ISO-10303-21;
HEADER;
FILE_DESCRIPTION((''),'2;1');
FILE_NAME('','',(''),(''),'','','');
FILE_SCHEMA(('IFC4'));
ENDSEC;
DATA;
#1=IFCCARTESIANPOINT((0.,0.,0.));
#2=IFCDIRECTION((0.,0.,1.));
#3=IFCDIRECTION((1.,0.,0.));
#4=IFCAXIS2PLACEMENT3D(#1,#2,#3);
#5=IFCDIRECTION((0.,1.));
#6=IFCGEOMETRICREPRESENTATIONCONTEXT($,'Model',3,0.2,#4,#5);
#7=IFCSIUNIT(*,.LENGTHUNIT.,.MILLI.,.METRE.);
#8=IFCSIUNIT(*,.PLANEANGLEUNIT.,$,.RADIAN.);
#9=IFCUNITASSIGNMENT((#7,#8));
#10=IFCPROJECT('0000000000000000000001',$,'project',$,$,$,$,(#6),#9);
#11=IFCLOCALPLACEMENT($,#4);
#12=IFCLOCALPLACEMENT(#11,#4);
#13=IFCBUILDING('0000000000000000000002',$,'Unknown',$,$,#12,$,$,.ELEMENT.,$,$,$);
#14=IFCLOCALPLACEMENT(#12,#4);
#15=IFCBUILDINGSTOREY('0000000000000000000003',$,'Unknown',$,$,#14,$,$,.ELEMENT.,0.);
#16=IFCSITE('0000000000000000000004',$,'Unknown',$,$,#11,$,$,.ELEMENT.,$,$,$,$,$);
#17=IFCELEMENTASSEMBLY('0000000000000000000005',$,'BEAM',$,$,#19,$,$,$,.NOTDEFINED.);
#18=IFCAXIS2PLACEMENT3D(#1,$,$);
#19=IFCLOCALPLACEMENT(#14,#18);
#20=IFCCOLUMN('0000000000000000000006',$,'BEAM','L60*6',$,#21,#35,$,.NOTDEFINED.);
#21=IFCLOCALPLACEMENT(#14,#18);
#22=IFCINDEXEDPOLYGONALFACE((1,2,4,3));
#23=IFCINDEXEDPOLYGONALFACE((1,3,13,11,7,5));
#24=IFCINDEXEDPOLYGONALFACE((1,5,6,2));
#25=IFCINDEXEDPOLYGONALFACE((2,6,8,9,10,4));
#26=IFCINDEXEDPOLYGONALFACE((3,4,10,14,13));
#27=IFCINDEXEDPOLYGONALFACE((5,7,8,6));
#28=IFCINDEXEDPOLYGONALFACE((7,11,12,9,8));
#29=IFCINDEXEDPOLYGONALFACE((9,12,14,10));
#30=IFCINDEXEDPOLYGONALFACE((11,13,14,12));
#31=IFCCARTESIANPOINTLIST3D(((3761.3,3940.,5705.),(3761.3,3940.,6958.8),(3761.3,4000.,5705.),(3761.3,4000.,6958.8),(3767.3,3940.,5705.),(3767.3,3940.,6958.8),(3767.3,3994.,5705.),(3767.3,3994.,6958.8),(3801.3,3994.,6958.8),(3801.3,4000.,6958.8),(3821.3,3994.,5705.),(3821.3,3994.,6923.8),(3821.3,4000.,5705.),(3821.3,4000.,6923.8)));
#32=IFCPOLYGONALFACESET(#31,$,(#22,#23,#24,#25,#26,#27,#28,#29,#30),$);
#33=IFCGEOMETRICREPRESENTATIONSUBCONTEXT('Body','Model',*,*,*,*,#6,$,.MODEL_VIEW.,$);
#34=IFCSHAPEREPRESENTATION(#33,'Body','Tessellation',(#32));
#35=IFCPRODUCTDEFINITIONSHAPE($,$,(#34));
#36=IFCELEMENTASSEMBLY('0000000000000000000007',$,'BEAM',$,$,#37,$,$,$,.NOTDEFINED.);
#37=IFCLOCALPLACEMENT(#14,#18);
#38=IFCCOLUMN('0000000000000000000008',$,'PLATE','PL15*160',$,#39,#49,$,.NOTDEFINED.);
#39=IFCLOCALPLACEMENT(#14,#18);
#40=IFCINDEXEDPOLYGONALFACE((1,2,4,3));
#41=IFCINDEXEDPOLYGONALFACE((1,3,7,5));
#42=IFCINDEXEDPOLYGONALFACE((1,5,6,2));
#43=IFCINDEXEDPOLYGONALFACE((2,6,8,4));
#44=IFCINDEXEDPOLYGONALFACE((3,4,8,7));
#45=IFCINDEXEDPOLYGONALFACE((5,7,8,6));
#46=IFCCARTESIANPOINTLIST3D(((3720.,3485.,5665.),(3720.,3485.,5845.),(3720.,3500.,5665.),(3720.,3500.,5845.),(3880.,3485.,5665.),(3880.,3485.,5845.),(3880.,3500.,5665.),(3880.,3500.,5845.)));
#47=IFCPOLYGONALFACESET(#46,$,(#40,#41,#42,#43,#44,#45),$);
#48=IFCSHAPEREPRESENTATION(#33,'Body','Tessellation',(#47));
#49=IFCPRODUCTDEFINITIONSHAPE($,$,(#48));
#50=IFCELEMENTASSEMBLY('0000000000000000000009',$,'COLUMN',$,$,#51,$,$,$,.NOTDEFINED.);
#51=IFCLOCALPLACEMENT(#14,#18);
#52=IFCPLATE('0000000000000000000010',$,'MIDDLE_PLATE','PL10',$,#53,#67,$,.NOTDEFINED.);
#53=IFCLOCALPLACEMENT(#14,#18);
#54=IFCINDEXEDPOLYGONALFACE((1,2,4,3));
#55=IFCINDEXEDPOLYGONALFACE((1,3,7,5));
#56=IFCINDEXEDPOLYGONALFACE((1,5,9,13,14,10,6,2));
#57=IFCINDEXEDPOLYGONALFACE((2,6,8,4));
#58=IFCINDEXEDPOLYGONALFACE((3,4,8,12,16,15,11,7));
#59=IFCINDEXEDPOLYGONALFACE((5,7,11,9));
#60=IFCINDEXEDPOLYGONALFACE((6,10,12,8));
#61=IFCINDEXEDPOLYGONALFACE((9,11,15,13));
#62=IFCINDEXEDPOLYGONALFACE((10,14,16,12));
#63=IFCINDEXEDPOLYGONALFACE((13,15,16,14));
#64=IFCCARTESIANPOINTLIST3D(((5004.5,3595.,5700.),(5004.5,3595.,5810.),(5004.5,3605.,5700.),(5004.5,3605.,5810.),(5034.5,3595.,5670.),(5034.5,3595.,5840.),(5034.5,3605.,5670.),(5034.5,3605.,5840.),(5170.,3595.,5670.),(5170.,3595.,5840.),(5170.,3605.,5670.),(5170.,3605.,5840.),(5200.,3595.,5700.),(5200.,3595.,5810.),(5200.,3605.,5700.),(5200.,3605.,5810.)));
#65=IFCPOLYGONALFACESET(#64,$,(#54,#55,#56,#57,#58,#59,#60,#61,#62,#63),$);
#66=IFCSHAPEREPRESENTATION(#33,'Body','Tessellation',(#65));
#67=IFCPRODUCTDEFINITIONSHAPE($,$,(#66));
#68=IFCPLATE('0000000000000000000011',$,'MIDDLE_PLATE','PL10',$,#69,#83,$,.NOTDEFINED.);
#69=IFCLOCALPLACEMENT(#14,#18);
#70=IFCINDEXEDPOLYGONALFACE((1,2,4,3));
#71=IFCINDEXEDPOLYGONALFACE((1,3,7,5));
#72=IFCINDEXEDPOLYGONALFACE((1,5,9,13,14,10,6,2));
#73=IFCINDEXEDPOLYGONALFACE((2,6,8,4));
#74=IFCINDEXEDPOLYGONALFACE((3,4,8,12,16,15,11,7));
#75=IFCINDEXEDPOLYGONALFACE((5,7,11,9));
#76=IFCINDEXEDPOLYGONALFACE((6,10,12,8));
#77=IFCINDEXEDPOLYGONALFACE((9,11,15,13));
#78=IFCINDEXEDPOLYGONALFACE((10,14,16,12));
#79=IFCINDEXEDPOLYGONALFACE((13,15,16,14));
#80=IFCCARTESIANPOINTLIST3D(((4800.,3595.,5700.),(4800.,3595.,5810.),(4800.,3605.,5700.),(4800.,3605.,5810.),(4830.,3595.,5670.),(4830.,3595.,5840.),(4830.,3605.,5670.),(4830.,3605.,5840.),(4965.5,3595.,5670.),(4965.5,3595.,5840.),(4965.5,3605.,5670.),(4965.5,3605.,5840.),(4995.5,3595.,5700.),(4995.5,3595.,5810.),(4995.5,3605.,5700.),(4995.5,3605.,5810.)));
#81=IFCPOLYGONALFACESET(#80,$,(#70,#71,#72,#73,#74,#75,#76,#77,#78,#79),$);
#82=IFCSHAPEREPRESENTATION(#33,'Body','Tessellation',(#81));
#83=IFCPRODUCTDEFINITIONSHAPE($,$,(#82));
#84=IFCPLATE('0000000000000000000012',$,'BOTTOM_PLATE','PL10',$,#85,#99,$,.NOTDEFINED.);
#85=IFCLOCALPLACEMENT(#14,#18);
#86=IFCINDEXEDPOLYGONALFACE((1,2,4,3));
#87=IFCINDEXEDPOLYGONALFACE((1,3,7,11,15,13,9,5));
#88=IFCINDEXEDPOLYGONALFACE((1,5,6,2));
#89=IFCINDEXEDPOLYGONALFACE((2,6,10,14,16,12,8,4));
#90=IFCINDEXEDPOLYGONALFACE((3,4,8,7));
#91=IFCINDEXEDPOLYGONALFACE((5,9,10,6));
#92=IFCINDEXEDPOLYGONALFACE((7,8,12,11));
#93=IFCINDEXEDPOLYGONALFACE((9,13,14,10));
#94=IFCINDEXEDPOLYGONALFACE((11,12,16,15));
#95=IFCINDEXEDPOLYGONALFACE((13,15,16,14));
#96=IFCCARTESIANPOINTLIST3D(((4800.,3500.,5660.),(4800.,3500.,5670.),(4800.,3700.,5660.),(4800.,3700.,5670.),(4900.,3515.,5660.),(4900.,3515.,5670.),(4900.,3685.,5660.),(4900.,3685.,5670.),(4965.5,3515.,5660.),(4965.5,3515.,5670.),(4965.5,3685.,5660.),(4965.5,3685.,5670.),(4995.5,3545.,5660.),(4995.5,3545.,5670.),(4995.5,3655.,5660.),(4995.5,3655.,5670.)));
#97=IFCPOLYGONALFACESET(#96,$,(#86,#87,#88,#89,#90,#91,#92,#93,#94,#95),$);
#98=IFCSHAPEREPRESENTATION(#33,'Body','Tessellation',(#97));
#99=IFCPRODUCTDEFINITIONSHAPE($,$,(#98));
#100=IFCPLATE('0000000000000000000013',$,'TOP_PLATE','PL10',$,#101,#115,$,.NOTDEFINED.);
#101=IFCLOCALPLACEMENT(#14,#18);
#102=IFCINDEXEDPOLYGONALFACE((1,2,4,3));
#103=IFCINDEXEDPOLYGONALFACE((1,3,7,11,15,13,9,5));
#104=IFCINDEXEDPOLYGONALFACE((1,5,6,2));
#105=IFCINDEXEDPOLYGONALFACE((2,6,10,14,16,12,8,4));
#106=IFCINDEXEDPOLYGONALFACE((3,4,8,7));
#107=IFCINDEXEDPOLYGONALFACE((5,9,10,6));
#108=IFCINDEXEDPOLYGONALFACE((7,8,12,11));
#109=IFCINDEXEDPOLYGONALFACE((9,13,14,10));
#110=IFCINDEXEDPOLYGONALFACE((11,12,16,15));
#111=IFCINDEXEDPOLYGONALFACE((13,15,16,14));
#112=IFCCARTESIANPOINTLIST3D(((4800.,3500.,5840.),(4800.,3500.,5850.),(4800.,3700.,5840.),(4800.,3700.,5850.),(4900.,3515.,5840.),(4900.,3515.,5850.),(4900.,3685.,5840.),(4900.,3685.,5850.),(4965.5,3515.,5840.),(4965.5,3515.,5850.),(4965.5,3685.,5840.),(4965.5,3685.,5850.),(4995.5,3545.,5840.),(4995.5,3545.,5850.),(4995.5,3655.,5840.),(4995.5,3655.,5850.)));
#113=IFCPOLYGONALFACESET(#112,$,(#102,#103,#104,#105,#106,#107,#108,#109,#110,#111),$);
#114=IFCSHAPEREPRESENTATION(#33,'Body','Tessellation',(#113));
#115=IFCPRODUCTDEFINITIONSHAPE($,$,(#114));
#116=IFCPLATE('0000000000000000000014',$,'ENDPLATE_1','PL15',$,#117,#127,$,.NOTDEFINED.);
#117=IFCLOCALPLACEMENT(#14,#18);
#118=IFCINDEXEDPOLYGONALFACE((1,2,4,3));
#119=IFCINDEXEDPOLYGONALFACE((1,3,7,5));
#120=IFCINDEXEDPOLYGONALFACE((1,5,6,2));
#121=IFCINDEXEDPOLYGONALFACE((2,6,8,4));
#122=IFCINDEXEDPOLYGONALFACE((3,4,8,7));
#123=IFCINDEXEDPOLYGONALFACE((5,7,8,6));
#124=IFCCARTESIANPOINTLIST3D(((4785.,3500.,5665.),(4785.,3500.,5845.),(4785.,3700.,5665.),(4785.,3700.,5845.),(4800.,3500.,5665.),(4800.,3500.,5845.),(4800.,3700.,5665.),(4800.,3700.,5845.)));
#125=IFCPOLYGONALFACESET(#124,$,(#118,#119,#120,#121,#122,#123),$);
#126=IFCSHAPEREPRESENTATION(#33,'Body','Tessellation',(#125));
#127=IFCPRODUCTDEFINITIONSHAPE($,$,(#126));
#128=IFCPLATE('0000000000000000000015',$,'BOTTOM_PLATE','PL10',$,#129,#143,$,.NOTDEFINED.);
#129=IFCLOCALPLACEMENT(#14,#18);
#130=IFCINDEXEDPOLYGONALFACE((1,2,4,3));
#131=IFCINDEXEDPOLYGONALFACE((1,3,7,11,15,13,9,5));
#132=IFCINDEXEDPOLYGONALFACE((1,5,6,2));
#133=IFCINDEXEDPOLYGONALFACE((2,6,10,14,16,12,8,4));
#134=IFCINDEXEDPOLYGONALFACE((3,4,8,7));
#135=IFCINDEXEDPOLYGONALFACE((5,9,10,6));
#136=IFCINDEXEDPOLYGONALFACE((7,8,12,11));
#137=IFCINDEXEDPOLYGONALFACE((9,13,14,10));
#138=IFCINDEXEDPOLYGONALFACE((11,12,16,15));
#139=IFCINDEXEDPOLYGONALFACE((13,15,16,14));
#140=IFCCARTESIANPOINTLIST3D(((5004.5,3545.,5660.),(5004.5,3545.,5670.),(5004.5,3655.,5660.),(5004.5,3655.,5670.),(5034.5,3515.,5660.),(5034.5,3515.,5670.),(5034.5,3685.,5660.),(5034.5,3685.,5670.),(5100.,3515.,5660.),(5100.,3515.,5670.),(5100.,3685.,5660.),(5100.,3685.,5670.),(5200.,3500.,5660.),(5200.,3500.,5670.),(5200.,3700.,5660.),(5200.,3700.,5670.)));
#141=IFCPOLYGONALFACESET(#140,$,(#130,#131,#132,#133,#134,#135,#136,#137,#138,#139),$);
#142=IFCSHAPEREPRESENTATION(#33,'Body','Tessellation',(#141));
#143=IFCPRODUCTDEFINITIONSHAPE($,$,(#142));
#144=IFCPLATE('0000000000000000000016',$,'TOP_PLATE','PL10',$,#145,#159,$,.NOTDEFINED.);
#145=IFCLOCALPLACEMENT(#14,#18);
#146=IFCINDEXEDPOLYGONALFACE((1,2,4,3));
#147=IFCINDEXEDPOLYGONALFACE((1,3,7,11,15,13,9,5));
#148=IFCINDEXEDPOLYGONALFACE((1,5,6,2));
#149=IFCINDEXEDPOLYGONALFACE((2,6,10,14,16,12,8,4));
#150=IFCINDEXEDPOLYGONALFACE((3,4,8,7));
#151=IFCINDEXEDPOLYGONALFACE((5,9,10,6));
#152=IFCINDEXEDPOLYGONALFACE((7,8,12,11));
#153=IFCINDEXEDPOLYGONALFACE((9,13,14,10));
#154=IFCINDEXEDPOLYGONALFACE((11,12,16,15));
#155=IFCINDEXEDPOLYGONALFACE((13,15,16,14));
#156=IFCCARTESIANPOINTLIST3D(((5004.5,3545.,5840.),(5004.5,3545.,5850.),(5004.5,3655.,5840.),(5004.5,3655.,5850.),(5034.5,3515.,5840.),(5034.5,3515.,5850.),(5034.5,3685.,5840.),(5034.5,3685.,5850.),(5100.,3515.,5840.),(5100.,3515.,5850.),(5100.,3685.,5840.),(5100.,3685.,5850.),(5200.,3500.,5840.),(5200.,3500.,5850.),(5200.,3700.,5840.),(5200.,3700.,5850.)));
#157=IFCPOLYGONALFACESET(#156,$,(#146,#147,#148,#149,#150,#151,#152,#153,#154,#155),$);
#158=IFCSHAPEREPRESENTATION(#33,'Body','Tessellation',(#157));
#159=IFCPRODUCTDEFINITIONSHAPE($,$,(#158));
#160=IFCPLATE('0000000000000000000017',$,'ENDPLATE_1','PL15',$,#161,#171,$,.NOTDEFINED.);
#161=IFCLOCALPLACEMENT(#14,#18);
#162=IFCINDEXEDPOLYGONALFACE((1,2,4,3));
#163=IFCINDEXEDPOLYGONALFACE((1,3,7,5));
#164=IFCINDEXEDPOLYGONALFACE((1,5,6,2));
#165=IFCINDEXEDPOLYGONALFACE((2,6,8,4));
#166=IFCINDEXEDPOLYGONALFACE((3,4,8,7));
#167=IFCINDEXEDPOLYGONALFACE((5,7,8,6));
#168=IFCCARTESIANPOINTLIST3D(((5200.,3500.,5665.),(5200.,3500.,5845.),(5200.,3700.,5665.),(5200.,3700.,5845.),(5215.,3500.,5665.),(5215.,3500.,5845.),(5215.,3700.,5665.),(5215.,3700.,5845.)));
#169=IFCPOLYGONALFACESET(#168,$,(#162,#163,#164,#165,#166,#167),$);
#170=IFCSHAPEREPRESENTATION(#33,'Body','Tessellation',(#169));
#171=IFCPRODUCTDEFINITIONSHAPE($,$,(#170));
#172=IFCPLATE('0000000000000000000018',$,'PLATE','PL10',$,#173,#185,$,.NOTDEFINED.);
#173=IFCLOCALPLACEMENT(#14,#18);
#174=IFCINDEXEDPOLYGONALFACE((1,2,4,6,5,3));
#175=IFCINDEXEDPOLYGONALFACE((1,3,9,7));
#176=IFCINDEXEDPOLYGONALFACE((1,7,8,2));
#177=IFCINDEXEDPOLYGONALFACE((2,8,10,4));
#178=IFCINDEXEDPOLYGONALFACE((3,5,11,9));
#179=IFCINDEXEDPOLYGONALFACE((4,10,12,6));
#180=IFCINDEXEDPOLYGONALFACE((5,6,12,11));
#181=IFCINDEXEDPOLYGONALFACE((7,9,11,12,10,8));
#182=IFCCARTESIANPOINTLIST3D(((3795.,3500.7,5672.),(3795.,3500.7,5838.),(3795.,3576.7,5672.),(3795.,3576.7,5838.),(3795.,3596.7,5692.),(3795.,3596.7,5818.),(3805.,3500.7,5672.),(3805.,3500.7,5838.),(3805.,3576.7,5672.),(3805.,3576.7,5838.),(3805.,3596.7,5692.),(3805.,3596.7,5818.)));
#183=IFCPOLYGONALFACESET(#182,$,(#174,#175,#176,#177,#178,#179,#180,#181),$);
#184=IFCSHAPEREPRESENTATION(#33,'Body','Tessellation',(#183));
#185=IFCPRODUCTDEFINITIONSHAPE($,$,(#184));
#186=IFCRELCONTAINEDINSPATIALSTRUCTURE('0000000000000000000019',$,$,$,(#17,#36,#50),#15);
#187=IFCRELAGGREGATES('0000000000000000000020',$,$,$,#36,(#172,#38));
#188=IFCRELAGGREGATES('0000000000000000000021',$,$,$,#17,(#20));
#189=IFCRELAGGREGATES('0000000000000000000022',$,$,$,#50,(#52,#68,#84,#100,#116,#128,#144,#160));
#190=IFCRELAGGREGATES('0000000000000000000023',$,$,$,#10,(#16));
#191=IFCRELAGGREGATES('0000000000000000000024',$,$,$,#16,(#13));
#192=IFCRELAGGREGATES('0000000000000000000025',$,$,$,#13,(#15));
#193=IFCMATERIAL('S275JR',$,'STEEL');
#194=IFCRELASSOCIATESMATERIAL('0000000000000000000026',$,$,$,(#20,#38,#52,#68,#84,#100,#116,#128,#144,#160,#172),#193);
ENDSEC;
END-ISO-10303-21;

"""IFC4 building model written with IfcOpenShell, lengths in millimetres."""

from ifc_helpers import new_model, si_unit, direction, frame, origin_with_axes, place, context, subcontext, project, spatial, line, indexed_curve, outline, extrude, material, element, aggregate, save


model = new_model("IFC4")

# Units and contexts
model_context = context("Model", 3, precision=0.2, world=origin_with_axes(), true_north=direction((0.0, 1.0)))
body_context = subcontext(model_context, "Body", "Model", "MODEL_VIEW")
ifc_project = project(units=[si_unit("LENGTHUNIT", "METRE", prefix="MILLI"), si_unit("PLANEANGLEUNIT", "RADIAN")], contexts=[model_context])

# Site, building, storey
site_placement = place(None, origin_with_axes())
site = spatial("IfcSite", under=ifc_project, at=site_placement, Name="Unknown", CompositionType="ELEMENT")
building_placement = place(site_placement, origin_with_axes())
building = spatial("IfcBuilding", under=site, at=building_placement, Name="Unknown", CompositionType="ELEMENT")
storey_placement = place(building_placement, origin_with_axes())
storey = spatial("IfcBuildingStorey", under=building, at=storey_placement, Name="Unknown", CompositionType="ELEMENT", Elevation=0.0)

# Shared definitions
ifc_material_1 = material(Name="S275JR", Category="STEEL")

# Element assembly, column, voiding feature
assembly_1_placement = place(storey_placement, frame((3791.3, 3970.0, 5705.0), z_axis=(1.0, 0.0, 0.0), x_axis=(0.0, 0.0, 1.0)))
assembly_1 = element("IfcElementAssembly", 1, at=assembly_1_placement, inside=storey, Name="BEAM", PredefinedType="NOTDEFINED")
column_1_placement = place(assembly_1_placement, origin_with_axes())
column_1 = element("IfcColumn", 2, at=column_1_placement, material=ifc_material_1, Name="BEAM", Description="L60*6", PredefinedType="NOTDEFINED", context=body_context, shape_type="SolidModel", body=[
    extrude(outline(indexed_curve([(-30.0, -30.0), (30.0, -30.0), (30.0, -24.0), (-24.0, -24.0), (-24.0, 30.0), (-30.0, 30.0)], segments=[line(1, 2, 3, 4, 5, 6, 1)])), frame((0.0, 0.0, 0.0), z_axis=(-1.0, 0.0, 0.0), x_axis=(0.0, 0.0, 1.0)), (0.0, -0.000002, -1.0), 1253.8),
])
voiding_feature_1_placement = place(column_1_placement, frame((1253.8, 0.0, 10.0), z_axis=(0.0, -1.0, 0.000002), x_axis=(0.0, 0.0, 1.0)))
element("IfcVoidingFeature", 3, at=voiding_feature_1_placement, cuts=column_1, Name="CUTPART", PredefinedType="HOLE", context=body_context, shape_type="SolidModel", body=[
    extrude(outline(indexed_curve([(0.0, 0.0), (20.0, 0.0), (20.0, 35.0)], segments=[line(1, 2, 3, 1)])), frame((0.0, 0.0, 33.0), z_axis=(0.0, 0.0, 1.0), x_axis=(1.0, 0.0, 0.0)), (0.0, -0.000002, -1.0), 66.0),
])

# Element assembly, column
assembly_2_placement = place(storey_placement, frame((600.0, 3600.0, 5755.0), z_axis=(-0.000002, -1.0, 0.0), x_axis=(1.0, 0.0, 0.0)))
assembly_2 = element("IfcElementAssembly", 4, at=assembly_2_placement, inside=storey, Name="BEAM", PredefinedType="NOTDEFINED")
column_2_placement = place(assembly_2_placement, frame((3200.0, -90.0, 107.5), z_axis=(0.0, 0.0, 1.0), x_axis=(0.0, 1.0, 0.0)))
column_2 = element("IfcColumn", 5, at=column_2_placement, material=ifc_material_1, Name="PLATE", Description="PL15*160", PredefinedType="NOTDEFINED", context=body_context, shape_type="SolidModel", body=[
    extrude(outline(indexed_curve([(-7.5, -80.0), (7.5, -80.0), (7.5, 80.0), (-7.5, 80.0)], segments=[line(1, 2, 3, 4, 1)])), frame((0.0, 0.0, 0.0), z_axis=(-1.0, 0.0, 0.0), x_axis=(0.0, 0.0, 1.0)), (0.0, -0.000002, -1.0), 180.0),
])

# Element assembly, plates
assembly_3_placement = place(storey_placement, frame((5000.0, 3600.0, 200.0), z_axis=(-1.0, 0.0, 0.0), x_axis=(0.0, 0.0, 1.0)))
assembly_3 = element("IfcElementAssembly", 6, at=assembly_3_placement, inside=storey, Name="COLUMN", PredefinedType="NOTDEFINED")
plate_1_placement = place(assembly_3_placement, frame((5640.0, 0.0, -200.0), z_axis=(-0.000002, -1.0, 0.0), x_axis=(0.0, 0.0, 1.0)))
plate_1 = element("IfcPlate", 7, at=plate_1_placement, material=ifc_material_1, Name="MIDDLE_PLATE", Description="PL10", PredefinedType="NOTDEFINED", context=body_context, shape_type="SolidModel", body=[
    extrude(outline(indexed_curve([(0.0, 30.0), (30.0, 0.0), (165.5, 0.0), (195.5, 30.0), (195.5, 140.0), (165.5, 170.0), (30.0, 170.0), (0.0, 140.0)], segments=[line(1, 2, 3, 4, 5, 6, 7, 8, 1)])), frame((0.0, 0.0, 5.0), z_axis=(0.0, 0.0, 1.0), x_axis=(1.0, 0.0, 0.0)), (0.0, -0.000002, -1.0), 10.0),
])
plate_2_placement = place(assembly_3_placement, frame((5640.0, 0.0, 200.0), z_axis=(0.0, 1.0, 0.0), x_axis=(0.0, -0.000002, -1.0)))
plate_2 = element("IfcPlate", 8, at=plate_2_placement, material=ifc_material_1, Name="MIDDLE_PLATE", Description="PL10", PredefinedType="NOTDEFINED", context=body_context, shape_type="SolidModel", body=[
    extrude(outline(indexed_curve([(0.0, 30.0), (30.0, 0.0), (165.5, 0.0), (195.5, 30.0), (195.5, 140.0), (165.5, 170.0), (30.0, 170.0), (0.0, 140.0)], segments=[line(1, 2, 3, 4, 5, 6, 7, 8, 1)])), frame((0.0, 0.0, 5.0), z_axis=(0.0, 0.0, 1.0), x_axis=(1.0, 0.0, 0.0)), (0.0, -0.000002, -1.0), 10.0),
])
plate_3_placement = place(assembly_3_placement, frame((5465.0, -85.0, 4.5), z_axis=(1.0, 0.0, 0.0), x_axis=(0.0, 1.0, 0.0)))
plate_3 = element("IfcPlate", 9, at=plate_3_placement, material=ifc_material_1, Name="BOTTOM_PLATE", Description="PL10", PredefinedType="NOTDEFINED", context=body_context, shape_type="SolidModel", body=[
    extrude(outline(indexed_curve([(0.0, 30.0), (30.0, 0.0), (140.0, 0.0), (170.0, 30.0), (170.0, 95.5), (185.0, 195.5), (-15.0, 195.5), (0.0, 95.5)], segments=[line(1, 2, 3, 4, 5, 6, 7, 8, 1)])), frame((0.0, 0.0, 5.0), z_axis=(0.0, 0.0, 1.0), x_axis=(1.0, 0.0, 0.0)), (0.0, -0.000002, -1.0), 10.0),
])
plate_4_placement = place(assembly_3_placement, frame((5645.0, -85.0, 100.0), z_axis=(1.0, 0.0, 0.0), x_axis=(0.0, -0.000002, -1.0)))
plate_4 = element("IfcPlate", 10, at=plate_4_placement, material=ifc_material_1, Name="TOP_PLATE", Description="PL10", PredefinedType="NOTDEFINED", context=body_context, shape_type="SolidModel", body=[
    extrude(outline(indexed_curve([(0.0, 0.0), (65.5, 0.0), (95.5, 30.0), (95.5, 140.0), (65.5, 170.0), (0.0, 170.0), (-100.0, 185.0), (-100.0, -15.0)], segments=[line(1, 2, 3, 4, 5, 6, 7, 8, 1)])), frame((0.0, 0.0, 5.0), z_axis=(0.0, 0.0, 1.0), x_axis=(1.0, 0.0, 0.0)), (0.0, -0.000002, -1.0), 10.0),
])
plate_5_placement = place(assembly_3_placement, frame((5465.0, -100.0, 207.5), z_axis=(0.0, 0.0, 1.0), x_axis=(1.0, 0.0, 0.0)))
plate_5 = element("IfcPlate", 11, at=plate_5_placement, material=ifc_material_1, Name="ENDPLATE_1", Description="PL15", PredefinedType="NOTDEFINED", context=body_context, shape_type="SolidModel", body=[
    extrude(outline(indexed_curve([(0.0, 0.0), (180.0, 0.0), (180.0, 200.0), (0.0, 200.0)], segments=[line(1, 2, 3, 4, 1)])), frame((0.0, 0.0, 7.5), z_axis=(0.0, 0.0, 1.0), x_axis=(1.0, 0.0, 0.0)), (0.0, -0.000002, -1.0), 15.0),
])
plate_6_placement = place(assembly_3_placement, frame((5465.0, 85.0, -4.5), z_axis=(1.0, 0.0, 0.0), x_axis=(-0.000002, -1.0, 0.0)))
plate_6 = element("IfcPlate", 12, at=plate_6_placement, material=ifc_material_1, Name="BOTTOM_PLATE", Description="PL10", PredefinedType="NOTDEFINED", context=body_context, shape_type="SolidModel", body=[
    extrude(outline(indexed_curve([(0.0, 30.0), (30.0, 0.0), (140.0, 0.0), (170.0, 30.0), (170.0, 95.5), (185.0, 195.5), (-15.0, 195.5), (0.0, 95.5)], segments=[line(1, 2, 3, 4, 5, 6, 7, 8, 1)])), frame((0.0, 0.0, 5.0), z_axis=(0.0, 0.0, 1.0), x_axis=(1.0, 0.0, 0.0)), (0.0, -0.000002, -1.0), 10.0),
])
plate_7_placement = place(assembly_3_placement, frame((5645.0, 85.0, -100.0), z_axis=(1.0, 0.0, 0.0), x_axis=(0.0, 0.0, 1.0)))
plate_7 = element("IfcPlate", 13, at=plate_7_placement, material=ifc_material_1, Name="TOP_PLATE", Description="PL10", PredefinedType="NOTDEFINED", context=body_context, shape_type="SolidModel", body=[
    extrude(outline(indexed_curve([(0.0, 0.0), (65.5, 0.0), (95.5, 30.0), (95.5, 140.0), (65.5, 170.0), (0.0, 170.0), (-100.0, 185.0), (-100.0, -15.0)], segments=[line(1, 2, 3, 4, 5, 6, 7, 8, 1)])), frame((0.0, 0.0, 5.0), z_axis=(0.0, 0.0, 1.0), x_axis=(1.0, 0.0, 0.0)), (0.0, -0.000002, -1.0), 10.0),
])
plate_8_placement = place(assembly_3_placement, frame((5465.0, 100.0, -207.5), z_axis=(0.0, -0.000002, -1.0), x_axis=(1.0, 0.0, 0.0)))
plate_8 = element("IfcPlate", 14, at=plate_8_placement, material=ifc_material_1, Name="ENDPLATE_1", Description="PL15", PredefinedType="NOTDEFINED", context=body_context, shape_type="SolidModel", body=[
    extrude(outline(indexed_curve([(0.0, 0.0), (180.0, 0.0), (180.0, 200.0), (0.0, 200.0)], segments=[line(1, 2, 3, 4, 1)])), frame((0.0, 0.0, 7.5), z_axis=(0.0, 0.0, 1.0), x_axis=(1.0, 0.0, 0.0)), (0.0, -0.000002, -1.0), 15.0),
])

# Plate
plate_9_placement = place(assembly_2_placement, frame((3200.0, -83.0, 3.2), z_axis=(-1.0, 0.0, 0.0), x_axis=(0.0, 0.0, 1.0)))
plate_9 = element("IfcPlate", 15, at=plate_9_placement, material=ifc_material_1, Name="PLATE", Description="PL10", PredefinedType="NOTDEFINED", context=body_context, shape_type="SolidModel", body=[
    extrude(outline(indexed_curve([(0.0, 20.0), (20.0, 0.0), (96.0, 0.0), (96.0, 166.0), (20.0, 166.0), (0.0, 146.0)], segments=[line(1, 2, 3, 4, 5, 6, 1)])), frame((0.0, 0.0, 5.0), z_axis=(0.0, 0.0, 1.0), x_axis=(1.0, 0.0, 0.0)), (0.0, -0.000002, -1.0), 10.0),
])
aggregate(assembly_2, [plate_9, column_2])

aggregate(assembly_1, [column_1])
aggregate(assembly_3, [plate_1, plate_2, plate_3, plate_4, plate_5, plate_6, plate_7, plate_8])

save(model, "model.ifc")
